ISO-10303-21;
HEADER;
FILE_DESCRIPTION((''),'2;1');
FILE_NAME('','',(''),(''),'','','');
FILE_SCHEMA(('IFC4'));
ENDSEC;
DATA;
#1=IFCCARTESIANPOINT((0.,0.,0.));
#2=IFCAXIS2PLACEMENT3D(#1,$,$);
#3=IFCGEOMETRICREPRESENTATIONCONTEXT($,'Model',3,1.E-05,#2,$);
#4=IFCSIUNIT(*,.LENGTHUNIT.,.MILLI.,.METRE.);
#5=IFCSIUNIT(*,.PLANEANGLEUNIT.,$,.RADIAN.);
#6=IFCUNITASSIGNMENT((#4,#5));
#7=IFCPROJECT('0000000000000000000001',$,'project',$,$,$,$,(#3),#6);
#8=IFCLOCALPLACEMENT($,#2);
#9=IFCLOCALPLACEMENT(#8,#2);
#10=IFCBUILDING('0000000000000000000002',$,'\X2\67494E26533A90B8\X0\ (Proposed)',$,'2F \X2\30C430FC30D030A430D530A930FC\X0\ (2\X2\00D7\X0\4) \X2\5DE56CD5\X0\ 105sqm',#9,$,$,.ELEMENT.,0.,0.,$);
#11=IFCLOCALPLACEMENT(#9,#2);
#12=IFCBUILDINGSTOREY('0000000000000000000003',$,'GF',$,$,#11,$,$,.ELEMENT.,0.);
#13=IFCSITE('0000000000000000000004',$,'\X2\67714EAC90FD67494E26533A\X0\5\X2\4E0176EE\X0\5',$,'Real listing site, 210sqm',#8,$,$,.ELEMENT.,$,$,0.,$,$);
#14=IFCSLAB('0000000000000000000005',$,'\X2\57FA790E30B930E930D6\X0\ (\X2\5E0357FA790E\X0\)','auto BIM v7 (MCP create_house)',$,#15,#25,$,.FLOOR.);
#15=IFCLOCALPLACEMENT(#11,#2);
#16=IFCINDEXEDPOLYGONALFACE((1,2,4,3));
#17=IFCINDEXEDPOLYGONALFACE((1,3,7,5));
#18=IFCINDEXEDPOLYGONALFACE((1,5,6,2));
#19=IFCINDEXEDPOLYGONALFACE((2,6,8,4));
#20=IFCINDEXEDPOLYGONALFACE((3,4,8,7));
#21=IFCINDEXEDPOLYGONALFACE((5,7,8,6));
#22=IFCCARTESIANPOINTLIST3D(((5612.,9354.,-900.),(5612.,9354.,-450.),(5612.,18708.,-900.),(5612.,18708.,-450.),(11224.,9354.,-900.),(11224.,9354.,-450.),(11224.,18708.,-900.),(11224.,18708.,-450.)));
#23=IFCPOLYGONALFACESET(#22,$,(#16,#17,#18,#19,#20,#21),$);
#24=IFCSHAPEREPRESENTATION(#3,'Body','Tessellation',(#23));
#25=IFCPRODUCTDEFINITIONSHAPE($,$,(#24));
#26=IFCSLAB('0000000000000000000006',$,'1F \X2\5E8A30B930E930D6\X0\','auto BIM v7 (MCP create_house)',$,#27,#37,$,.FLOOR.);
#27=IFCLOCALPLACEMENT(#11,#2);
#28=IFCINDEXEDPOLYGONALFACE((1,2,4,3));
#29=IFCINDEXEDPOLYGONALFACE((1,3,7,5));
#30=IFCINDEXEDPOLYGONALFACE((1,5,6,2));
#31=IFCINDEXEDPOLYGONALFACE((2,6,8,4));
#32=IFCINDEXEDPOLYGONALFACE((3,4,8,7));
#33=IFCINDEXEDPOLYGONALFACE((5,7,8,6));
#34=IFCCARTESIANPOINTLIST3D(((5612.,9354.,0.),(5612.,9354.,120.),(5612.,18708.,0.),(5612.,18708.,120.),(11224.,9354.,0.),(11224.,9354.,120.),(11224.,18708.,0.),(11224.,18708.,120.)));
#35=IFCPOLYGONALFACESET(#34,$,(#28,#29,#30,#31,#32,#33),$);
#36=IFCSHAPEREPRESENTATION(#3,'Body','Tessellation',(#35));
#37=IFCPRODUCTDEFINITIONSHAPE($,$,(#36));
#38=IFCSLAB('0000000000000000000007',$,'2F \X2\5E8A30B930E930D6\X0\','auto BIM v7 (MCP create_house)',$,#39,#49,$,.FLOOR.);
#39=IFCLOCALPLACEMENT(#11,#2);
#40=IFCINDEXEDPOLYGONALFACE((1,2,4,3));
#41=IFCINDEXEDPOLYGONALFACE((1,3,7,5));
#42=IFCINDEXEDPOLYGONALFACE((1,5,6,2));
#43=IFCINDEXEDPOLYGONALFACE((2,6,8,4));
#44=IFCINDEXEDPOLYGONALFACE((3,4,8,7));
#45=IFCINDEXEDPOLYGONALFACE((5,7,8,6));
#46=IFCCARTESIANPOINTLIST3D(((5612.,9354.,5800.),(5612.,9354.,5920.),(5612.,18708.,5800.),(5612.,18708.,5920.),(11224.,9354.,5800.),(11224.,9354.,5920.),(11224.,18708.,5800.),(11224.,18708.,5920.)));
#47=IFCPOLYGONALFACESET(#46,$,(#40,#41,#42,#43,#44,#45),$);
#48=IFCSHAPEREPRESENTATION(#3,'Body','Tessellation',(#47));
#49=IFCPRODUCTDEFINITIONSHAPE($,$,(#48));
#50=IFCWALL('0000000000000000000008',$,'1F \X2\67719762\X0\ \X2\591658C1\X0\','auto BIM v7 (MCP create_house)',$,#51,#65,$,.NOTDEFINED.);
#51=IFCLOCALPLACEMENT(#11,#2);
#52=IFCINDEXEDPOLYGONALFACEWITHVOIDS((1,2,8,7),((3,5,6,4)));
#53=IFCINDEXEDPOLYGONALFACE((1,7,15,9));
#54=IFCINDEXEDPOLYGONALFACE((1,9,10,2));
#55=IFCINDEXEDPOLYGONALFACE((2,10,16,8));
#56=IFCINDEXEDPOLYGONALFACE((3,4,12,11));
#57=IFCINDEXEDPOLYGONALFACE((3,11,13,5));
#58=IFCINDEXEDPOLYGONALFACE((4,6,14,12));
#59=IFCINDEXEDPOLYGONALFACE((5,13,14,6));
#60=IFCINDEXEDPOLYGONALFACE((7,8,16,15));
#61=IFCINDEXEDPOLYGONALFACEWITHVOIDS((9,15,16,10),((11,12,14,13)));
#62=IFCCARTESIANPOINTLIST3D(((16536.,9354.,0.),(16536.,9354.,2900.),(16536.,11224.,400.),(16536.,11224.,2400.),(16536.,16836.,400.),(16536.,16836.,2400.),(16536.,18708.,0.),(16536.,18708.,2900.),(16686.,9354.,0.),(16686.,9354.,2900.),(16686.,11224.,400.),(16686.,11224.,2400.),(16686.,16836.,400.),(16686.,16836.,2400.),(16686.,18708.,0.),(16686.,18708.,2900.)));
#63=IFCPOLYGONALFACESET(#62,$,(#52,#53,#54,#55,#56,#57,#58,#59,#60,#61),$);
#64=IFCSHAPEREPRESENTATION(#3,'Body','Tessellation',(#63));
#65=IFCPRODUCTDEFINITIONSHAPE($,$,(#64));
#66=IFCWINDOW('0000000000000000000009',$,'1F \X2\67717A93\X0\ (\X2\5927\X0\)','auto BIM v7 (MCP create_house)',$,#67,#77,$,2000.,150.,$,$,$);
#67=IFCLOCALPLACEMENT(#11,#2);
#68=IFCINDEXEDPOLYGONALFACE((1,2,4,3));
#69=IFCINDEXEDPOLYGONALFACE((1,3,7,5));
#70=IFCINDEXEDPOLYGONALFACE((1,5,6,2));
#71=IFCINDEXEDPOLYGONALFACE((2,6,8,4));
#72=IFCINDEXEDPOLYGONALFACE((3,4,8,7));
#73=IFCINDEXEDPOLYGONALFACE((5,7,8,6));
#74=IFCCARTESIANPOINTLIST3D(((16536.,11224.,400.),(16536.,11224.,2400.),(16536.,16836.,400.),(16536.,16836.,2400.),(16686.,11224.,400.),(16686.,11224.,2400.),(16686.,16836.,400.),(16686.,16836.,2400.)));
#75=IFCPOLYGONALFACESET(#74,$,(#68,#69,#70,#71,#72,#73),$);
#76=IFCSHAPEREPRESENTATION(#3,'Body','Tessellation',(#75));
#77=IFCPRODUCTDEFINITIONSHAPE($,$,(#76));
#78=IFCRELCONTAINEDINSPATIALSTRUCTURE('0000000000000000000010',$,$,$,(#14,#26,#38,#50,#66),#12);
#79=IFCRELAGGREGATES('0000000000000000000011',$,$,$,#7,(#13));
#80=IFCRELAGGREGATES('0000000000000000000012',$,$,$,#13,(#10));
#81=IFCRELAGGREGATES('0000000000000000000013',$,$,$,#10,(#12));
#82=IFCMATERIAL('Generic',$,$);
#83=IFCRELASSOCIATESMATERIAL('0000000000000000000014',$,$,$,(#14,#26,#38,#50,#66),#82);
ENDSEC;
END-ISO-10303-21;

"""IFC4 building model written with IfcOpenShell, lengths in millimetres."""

from ifc_helpers import new_model, si_unit, frame, frame_2d, origin, place, context, project, spatial, rectangle, extrude, material, element, fill, save


model = new_model("IFC4")

# Units and contexts
model_context = context("Model", 3, precision=1e-05, world=origin())
ifc_project = project(units=[si_unit("LENGTHUNIT", "METRE", prefix="MILLI"), si_unit("PLANEANGLEUNIT", "RADIAN")], contexts=[model_context])

# Site, building, storey
site_placement = place(None, origin())
site = spatial("IfcSite", under=ifc_project, at=site_placement, Name="東京都杉並区5丁目5", ObjectType="Real listing site, 210sqm", CompositionType="ELEMENT", RefElevation=0.0)
building_placement = place(site_placement, origin())
building = spatial("IfcBuilding", under=site, at=building_placement, Name="杉並区邸 (Proposed)", ObjectType="2F ツーバイフォー (2×4) 工法 105sqm", CompositionType="ELEMENT", ElevationOfRefHeight=0.0, ElevationOfTerrain=0.0)
storey_placement = place(building_placement, origin())
storey = spatial("IfcBuildingStorey", under=building, at=storey_placement, Name="GF", CompositionType="ELEMENT", Elevation=0.0)

# Slabs
ifc_material = material(Name="Generic")
slab_1_placement = place(storey_placement, frame((2806.0, 4677.0, -450.0)))
element("IfcSlab", 1, at=slab_1_placement, inside=storey, material=ifc_material, Name="基礎スラブ (布基礎)", Description="auto BIM v7 (MCP create_house)", PredefinedType="FLOOR", context=model_context, shape_type="SweptSolid", body=[
    extrude(rectangle(XDim=5612.0, YDim=9354.0, at=frame_2d((2806.0, 4677.0))), frame((2806.0, 4677.0, -450.0)), (0.0, 0.0, 1.0), 450.0),
])
slab_2_placement = place(storey_placement, frame((2806.0, 4677.0, 0.0)))
element("IfcSlab", 2, at=slab_2_placement, inside=storey, material=ifc_material, Name="1F 床スラブ", Description="auto BIM v7 (MCP create_house)", PredefinedType="FLOOR", context=model_context, shape_type="SweptSolid", body=[
    extrude(rectangle(XDim=5612.0, YDim=9354.0, at=frame_2d((2806.0, 4677.0))), frame((2806.0, 4677.0, 0.0)), (0.0, 0.0, 1.0), 120.0),
])
slab_3_placement = place(storey_placement, frame((2806.0, 4677.0, 2900.0)))
element("IfcSlab", 3, at=slab_3_placement, inside=storey, material=ifc_material, Name="2F 床スラブ", Description="auto BIM v7 (MCP create_house)", PredefinedType="FLOOR", context=model_context, shape_type="SweptSolid", body=[
    extrude(rectangle(XDim=5612.0, YDim=9354.0, at=frame_2d((2806.0, 4677.0))), frame((2806.0, 4677.0, 2900.0)), (0.0, 0.0, 1.0), 120.0),
])

# Wall, opening, window
wall_1_placement = place(storey_placement, frame((8268.0, 4677.0, 0.0)))
wall_1 = element("IfcWall", 4, at=wall_1_placement, inside=storey, material=ifc_material, Name="1F 東面 外壁", Description="auto BIM v7 (MCP create_house)", PredefinedType="NOTDEFINED", context=model_context, shape_type="SweptSolid", body=[
    extrude(rectangle(XDim=150.0, YDim=9354.0, at=frame_2d((75.0, 4677.0))), frame((8268.0, 4677.0, 0.0)), (0.0, 0.0, 1.0), 2900.0),
])
opening_1_placement = place(storey_placement, frame((8268.0, 5612.0, 200.0)))
opening_1 = element("IfcOpeningElement", 5, at=opening_1_placement, cuts=wall_1, PredefinedType="NOTDEFINED", context=model_context, shape_type="SweptSolid", body=[
    extrude(rectangle(XDim=150.0, YDim=5612.0, at=frame_2d((75.0, 2806.0))), frame((8268.0, 5612.0, 200.0)), (0.0, 0.0, 1.0), 2000.0),
])
window_1_placement = place(storey_placement, frame((8268.0, 5612.0, 200.0)))
window_1 = element("IfcWindow", 6, at=window_1_placement, inside=storey, material=ifc_material, Name="1F 東窓 (大)", Description="auto BIM v7 (MCP create_house)", OverallHeight=2000.0, OverallWidth=150.0, context=model_context, shape_type="SweptSolid", body=[
    extrude(rectangle(XDim=150.0, YDim=5612.0, at=frame_2d((75.0, 2806.0))), frame((8268.0, 5612.0, 200.0)), (0.0, 0.0, 1.0), 2000.0),
])
fill(opening_1, window_1)

save(model, "model.ifc")
